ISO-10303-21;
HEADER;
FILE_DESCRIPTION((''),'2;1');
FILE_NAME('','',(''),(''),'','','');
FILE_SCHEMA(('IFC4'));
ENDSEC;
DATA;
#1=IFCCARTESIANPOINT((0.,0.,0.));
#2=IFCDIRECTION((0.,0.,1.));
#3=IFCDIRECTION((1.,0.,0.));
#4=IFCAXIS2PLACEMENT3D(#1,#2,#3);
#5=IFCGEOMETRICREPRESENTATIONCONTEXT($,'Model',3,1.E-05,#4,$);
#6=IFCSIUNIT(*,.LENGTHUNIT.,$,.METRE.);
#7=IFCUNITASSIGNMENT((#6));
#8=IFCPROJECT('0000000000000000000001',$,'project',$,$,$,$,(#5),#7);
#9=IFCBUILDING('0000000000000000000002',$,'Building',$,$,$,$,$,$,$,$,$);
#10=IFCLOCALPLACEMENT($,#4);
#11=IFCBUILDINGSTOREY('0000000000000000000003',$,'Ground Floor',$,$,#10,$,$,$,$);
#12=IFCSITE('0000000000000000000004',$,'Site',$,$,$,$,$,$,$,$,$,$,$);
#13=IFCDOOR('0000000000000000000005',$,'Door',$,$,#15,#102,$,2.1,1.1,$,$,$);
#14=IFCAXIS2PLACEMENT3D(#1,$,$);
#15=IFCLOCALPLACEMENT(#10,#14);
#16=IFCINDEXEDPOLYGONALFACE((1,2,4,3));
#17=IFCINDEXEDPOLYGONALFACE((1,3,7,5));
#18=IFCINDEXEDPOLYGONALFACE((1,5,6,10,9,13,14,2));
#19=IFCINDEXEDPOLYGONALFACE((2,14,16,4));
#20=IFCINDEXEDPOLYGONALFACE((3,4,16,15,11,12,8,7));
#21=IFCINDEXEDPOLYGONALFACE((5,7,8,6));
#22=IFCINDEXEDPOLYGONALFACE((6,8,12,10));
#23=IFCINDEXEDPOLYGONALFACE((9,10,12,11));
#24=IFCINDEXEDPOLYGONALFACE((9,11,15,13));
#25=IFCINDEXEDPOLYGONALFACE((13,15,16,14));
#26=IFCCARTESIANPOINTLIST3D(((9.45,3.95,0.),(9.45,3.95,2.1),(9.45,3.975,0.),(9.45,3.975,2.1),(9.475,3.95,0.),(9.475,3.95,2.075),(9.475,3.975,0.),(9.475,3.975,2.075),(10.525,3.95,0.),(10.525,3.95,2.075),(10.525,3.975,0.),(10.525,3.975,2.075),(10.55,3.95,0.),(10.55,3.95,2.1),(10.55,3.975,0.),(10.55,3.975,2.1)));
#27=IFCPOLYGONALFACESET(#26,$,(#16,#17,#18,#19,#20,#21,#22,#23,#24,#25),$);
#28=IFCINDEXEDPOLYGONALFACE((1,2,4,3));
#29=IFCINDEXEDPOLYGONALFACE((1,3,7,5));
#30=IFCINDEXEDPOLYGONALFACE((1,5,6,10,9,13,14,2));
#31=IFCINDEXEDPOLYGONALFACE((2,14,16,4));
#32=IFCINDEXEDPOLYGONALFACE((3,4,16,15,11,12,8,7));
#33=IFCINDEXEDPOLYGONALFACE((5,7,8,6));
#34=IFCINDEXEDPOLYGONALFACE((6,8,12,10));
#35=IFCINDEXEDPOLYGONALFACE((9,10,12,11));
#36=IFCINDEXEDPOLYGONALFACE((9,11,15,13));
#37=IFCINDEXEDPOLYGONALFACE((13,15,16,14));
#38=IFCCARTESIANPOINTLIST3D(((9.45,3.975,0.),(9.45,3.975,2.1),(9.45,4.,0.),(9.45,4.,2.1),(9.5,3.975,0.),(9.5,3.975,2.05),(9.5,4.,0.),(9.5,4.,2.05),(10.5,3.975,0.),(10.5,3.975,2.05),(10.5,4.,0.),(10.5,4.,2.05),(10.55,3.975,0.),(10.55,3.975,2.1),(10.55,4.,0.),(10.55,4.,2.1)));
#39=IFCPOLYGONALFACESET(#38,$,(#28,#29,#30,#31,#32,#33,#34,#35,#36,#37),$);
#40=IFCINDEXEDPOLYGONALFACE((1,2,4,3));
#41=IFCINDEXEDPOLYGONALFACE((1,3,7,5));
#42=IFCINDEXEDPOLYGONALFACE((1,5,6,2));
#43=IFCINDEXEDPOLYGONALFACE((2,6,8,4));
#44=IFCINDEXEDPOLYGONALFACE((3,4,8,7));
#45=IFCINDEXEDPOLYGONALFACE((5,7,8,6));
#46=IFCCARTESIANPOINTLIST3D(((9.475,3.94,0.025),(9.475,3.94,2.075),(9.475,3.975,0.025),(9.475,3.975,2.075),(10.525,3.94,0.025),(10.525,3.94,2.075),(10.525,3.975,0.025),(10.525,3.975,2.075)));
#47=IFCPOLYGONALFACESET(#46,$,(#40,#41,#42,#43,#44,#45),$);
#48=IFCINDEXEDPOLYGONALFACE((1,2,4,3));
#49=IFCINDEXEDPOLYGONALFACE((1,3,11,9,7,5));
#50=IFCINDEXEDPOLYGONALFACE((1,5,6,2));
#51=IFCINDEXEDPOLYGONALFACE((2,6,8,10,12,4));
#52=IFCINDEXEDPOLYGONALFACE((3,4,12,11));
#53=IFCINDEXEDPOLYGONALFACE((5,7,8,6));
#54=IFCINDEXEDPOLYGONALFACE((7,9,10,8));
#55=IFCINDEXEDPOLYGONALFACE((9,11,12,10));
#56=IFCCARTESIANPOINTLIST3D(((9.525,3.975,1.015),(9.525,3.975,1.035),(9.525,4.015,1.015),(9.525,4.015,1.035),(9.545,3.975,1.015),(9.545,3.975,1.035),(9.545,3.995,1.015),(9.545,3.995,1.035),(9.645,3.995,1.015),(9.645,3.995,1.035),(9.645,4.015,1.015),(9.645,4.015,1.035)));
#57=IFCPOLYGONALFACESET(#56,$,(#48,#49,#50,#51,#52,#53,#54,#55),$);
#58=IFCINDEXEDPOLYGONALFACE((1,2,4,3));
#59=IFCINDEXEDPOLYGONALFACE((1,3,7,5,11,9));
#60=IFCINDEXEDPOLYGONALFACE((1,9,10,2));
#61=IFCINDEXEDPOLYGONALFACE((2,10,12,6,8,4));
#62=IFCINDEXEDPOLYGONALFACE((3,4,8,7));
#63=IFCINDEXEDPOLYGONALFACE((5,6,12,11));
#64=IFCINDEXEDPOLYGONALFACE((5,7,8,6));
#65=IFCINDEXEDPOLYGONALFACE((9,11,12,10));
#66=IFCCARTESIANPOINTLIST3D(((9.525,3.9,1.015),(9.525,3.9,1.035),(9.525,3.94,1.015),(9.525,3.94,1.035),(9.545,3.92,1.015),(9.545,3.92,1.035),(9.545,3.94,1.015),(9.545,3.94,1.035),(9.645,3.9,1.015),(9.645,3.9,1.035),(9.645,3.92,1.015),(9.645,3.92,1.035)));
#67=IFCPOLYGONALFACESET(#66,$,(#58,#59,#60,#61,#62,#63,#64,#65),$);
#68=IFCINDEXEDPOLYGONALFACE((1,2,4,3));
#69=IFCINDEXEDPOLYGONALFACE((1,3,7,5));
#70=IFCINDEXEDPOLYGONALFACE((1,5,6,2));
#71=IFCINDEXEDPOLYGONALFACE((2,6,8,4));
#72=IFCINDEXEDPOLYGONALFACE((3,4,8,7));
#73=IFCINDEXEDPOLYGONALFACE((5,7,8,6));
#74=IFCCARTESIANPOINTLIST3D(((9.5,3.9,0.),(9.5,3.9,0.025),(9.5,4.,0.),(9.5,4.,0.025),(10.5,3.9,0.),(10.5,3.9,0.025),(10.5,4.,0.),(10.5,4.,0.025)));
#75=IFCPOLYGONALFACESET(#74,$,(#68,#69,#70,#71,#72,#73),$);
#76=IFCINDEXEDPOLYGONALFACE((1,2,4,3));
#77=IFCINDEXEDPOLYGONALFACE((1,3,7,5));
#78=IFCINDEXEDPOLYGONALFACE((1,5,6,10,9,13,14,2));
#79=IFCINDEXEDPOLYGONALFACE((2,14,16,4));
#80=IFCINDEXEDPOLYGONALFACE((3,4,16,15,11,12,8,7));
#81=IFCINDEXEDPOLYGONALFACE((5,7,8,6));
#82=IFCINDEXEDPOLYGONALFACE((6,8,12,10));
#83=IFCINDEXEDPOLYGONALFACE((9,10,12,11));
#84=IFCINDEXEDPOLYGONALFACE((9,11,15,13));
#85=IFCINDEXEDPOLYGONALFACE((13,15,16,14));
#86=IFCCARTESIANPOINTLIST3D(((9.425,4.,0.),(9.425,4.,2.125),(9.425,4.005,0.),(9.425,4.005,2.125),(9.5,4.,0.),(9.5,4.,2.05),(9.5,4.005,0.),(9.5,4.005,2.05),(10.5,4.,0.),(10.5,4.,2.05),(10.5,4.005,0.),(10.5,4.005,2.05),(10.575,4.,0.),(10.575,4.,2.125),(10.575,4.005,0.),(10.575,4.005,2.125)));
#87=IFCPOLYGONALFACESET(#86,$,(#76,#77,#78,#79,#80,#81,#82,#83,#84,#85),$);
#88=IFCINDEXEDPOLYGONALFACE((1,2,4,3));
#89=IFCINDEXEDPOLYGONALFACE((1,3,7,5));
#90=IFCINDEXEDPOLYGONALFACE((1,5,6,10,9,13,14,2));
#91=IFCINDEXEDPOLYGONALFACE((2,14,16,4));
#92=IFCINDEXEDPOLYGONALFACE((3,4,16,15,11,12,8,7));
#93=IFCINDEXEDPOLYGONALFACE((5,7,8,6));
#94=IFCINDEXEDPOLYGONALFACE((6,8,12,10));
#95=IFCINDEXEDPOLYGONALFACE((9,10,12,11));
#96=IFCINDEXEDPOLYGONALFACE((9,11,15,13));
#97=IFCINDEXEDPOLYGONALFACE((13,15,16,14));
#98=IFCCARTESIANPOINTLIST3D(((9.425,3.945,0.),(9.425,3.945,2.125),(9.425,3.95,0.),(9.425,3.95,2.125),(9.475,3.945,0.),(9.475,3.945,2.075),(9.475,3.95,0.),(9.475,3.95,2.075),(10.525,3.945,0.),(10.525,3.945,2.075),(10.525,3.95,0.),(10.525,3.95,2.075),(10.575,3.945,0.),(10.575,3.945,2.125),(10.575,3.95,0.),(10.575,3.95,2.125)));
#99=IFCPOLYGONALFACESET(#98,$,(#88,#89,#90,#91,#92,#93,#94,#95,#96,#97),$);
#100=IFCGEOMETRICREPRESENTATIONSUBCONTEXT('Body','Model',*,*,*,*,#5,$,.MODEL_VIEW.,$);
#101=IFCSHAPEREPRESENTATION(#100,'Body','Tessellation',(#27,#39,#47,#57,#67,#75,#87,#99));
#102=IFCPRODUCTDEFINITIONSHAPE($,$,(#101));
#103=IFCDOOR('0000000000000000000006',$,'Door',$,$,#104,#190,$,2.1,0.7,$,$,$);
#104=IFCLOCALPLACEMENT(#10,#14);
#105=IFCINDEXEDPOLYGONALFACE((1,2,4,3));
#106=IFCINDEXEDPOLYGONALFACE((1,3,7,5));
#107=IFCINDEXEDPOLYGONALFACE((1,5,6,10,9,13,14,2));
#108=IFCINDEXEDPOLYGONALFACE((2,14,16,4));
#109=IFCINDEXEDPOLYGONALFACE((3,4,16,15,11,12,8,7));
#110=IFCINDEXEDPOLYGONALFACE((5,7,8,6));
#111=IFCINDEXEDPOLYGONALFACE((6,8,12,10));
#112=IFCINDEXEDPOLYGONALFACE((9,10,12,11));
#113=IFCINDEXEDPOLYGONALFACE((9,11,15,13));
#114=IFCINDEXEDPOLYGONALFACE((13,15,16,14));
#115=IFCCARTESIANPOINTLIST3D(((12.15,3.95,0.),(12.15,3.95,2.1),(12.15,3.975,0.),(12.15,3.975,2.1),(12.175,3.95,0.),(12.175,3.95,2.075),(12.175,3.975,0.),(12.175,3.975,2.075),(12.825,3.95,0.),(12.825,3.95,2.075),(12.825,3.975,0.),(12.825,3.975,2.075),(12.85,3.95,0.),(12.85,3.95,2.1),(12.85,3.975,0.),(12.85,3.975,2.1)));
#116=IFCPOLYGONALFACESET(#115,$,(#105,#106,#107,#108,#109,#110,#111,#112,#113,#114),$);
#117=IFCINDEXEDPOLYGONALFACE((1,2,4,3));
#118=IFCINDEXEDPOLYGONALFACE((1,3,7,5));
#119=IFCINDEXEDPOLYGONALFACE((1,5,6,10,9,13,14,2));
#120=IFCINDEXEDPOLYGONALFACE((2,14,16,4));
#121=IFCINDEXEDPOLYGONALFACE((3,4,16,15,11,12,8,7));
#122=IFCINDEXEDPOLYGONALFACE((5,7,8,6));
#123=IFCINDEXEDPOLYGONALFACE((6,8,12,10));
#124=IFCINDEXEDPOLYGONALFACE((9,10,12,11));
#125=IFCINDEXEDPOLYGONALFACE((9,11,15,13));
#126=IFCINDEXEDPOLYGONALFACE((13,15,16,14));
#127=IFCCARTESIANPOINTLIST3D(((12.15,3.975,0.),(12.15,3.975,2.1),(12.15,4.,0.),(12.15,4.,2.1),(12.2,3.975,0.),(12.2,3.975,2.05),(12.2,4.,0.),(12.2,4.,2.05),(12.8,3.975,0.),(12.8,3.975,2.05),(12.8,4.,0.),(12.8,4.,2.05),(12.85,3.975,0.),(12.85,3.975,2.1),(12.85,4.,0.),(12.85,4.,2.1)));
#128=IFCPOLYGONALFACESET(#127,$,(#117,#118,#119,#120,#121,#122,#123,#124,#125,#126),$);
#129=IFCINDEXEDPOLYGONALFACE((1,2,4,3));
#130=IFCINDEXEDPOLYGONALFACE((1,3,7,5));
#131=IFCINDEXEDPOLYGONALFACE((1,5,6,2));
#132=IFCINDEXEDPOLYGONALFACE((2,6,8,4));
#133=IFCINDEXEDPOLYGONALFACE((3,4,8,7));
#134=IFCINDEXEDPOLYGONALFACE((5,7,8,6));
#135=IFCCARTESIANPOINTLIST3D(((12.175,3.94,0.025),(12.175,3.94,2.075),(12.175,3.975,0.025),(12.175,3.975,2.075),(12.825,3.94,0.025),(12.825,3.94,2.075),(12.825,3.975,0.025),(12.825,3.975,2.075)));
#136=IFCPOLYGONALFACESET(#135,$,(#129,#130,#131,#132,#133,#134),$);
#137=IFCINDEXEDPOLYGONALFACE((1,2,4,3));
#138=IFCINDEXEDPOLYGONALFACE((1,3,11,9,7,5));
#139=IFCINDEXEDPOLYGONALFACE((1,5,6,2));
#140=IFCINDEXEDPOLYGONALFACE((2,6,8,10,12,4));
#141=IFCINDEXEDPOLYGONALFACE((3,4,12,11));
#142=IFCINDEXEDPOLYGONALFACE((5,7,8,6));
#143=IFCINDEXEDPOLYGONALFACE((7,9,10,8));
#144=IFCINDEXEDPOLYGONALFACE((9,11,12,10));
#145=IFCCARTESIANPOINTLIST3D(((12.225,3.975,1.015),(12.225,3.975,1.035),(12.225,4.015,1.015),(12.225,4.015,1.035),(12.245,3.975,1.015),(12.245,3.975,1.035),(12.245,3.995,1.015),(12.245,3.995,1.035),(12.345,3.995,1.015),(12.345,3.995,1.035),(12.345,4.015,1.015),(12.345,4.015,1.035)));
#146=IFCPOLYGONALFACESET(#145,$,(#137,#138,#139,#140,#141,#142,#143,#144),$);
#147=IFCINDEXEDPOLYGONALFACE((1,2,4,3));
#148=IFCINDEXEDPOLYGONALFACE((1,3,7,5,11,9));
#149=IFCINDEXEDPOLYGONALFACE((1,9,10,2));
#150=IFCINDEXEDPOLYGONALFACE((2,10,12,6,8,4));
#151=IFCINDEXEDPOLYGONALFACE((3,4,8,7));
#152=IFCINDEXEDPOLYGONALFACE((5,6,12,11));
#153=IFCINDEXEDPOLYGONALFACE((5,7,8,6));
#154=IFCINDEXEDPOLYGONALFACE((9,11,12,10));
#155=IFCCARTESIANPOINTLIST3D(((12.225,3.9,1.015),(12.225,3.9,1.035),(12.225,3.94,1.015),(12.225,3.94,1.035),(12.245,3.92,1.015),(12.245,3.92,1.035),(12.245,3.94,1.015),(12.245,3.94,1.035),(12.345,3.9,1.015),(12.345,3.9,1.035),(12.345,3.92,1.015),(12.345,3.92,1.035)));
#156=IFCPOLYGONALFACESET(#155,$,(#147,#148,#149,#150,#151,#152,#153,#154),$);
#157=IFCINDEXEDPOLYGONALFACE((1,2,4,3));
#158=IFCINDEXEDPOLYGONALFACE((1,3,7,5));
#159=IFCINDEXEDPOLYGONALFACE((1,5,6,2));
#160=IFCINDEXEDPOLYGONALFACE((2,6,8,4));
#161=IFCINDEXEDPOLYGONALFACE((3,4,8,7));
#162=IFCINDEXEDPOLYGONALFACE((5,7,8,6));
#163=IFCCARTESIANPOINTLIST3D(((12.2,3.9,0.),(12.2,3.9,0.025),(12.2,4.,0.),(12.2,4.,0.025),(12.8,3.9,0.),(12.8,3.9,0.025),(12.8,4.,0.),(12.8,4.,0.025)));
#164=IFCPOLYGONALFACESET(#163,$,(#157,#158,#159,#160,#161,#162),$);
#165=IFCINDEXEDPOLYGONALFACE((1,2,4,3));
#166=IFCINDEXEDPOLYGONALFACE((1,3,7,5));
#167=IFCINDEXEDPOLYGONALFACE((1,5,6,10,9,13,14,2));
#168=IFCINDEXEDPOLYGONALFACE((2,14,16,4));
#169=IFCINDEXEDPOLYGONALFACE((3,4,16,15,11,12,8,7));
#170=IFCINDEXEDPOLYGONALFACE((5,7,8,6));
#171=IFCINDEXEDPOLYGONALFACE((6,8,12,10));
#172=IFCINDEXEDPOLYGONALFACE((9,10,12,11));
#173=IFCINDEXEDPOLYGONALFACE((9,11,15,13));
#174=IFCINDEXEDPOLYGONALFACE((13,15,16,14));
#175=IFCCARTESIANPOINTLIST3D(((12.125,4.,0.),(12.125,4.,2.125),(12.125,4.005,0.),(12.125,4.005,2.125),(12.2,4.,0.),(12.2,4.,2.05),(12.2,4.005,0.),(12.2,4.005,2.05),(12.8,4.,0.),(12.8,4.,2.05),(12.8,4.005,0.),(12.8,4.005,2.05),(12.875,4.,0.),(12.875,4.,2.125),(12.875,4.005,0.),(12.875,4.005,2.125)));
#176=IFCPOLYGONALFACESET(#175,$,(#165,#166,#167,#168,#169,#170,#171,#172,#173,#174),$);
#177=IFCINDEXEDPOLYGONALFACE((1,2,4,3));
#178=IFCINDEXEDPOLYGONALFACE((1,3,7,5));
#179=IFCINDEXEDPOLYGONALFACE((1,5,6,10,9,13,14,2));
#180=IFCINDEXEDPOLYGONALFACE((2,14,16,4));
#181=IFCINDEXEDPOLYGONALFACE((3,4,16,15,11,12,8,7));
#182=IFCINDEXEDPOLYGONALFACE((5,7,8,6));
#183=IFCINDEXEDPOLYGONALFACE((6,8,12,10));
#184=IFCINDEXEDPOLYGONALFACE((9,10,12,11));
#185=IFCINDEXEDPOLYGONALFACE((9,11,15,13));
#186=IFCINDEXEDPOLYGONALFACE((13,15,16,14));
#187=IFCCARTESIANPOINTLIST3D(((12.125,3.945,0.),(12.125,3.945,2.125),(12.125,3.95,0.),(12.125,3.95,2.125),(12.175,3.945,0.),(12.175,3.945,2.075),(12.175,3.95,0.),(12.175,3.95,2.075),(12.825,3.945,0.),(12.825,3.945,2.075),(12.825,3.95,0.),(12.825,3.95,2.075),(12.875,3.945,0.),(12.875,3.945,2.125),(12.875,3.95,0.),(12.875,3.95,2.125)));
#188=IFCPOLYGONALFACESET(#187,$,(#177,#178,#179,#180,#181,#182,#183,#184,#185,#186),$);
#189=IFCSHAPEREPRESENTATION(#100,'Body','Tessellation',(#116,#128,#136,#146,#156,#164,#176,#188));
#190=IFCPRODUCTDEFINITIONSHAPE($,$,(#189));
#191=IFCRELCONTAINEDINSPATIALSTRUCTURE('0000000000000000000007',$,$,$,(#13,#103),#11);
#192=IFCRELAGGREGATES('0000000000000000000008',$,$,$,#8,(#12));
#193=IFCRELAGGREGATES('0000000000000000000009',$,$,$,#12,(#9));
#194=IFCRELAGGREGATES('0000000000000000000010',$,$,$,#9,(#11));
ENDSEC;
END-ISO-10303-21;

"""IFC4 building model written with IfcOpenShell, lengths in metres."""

from ifc_helpers import new_model, si_unit, frame, origin_with_axes, place, context, subcontext, project, spatial, line, indexed_curve, outline, extrude, element, save


model = new_model("IFC4")

# Units and contexts
model_context = context("Model", 3, precision=1e-05, world=origin_with_axes())
body_context = subcontext(model_context, "Body", "Model", "MODEL_VIEW")
ifc_project = project(units=[si_unit("LENGTHUNIT", "METRE")], contexts=[model_context])

# Site, building, storey
site = spatial("IfcSite", under=ifc_project, Name="Site")
building = spatial("IfcBuilding", under=site, Name="Building")
storey_placement = place(None, origin_with_axes())
storey = spatial("IfcBuildingStorey", under=building, at=storey_placement, Name="Ground Floor")

# Doors
door_1_placement = place(storey_placement, frame((10.55, 4.0, 0.0), z_axis=(0.0, 0.0, 1.0), x_axis=(-1.0, 0.0, 0.0)))
element("IfcDoor", 1, at=door_1_placement, inside=storey, Name="Door", OverallHeight=2.1, OverallWidth=1.1, context=body_context, shape_type="SweptSolid", body=[
    extrude(outline(indexed_curve([(0.0, 0.0), (0.0, 2.1), (1.1, 2.1), (1.1, 0.0), (1.075, 0.0), (1.075, 2.075), (0.025, 2.075), (0.025, 0.0)], segments=[line(1, 2, 3, 4, 5, 6, 7, 8, 1)])), frame((0.0, 0.025, 0.0), z_axis=(0.0, -1.0, 0.0), x_axis=(1.0, 0.0, 0.0)), (0.0, 0.0, -1.0), 0.025),
    extrude(outline(indexed_curve([(0.0, 0.0), (0.0, 2.1), (1.1, 2.1), (1.1, 0.0), (1.05, 0.0), (1.05, 2.05), (0.05, 2.05), (0.05, 0.0)], segments=[line(1, 2, 3, 4, 5, 6, 7, 8, 1)])), frame((0.0, 0.0, 0.0), z_axis=(0.0, -1.0, 0.0), x_axis=(1.0, 0.0, 0.0)), (0.0, 0.0, -1.0), 0.025),
    extrude(outline(indexed_curve([(0.0, 0.0), (1.05, 0.0), (1.05, 0.035), (0.0, 0.035)], segments=[line(1, 2, 3, 4, 1)])), frame((0.025, 0.025, 0.025), z_axis=(0.0, 0.0, 1.0), x_axis=(1.0, 0.0, 0.0)), (0.0, 0.0, 1.0), 2.05),
    extrude(outline(indexed_curve([(0.0, 0.0), (0.0, -0.04), (-0.12, -0.04), (-0.12, -0.02), (-0.02, -0.02), (-0.02, 0.0)], segments=[line(1, 2, 3, 4, 5, 6, 1)])), frame((1.025, 0.025, 1.015), z_axis=(0.0, 0.0, 1.0), x_axis=(1.0, 0.0, 0.0)), (0.0, 0.0, 1.0), 0.02),
    extrude(outline(indexed_curve([(0.0, 0.0), (0.0, 0.04), (-0.12, 0.04), (-0.12, 0.02), (-0.02, 0.02), (-0.02, 0.0)], segments=[line(1, 2, 3, 4, 5, 6, 1)])), frame((1.025, 0.06, 1.015), z_axis=(0.0, 0.0, 1.0), x_axis=(1.0, 0.0, 0.0)), (0.0, 0.0, 1.0), 0.02),
    extrude(outline(indexed_curve([(0.0, 0.0), (1.0, 0.0), (1.0, 0.1), (0.0, 0.1)], segments=[line(1, 2, 3, 4, 1)])), frame((0.05, 0.0, 0.0), z_axis=(0.0, 0.0, 1.0), x_axis=(1.0, 0.0, 0.0)), (0.0, 0.0, 1.0), 0.025),
    extrude(outline(indexed_curve([(0.0, 0.0), (0.0, 2.125), (1.15, 2.125), (1.15, 0.0), (1.075, 0.0), (1.075, 2.05), (0.075, 2.05), (0.075, 0.0)], segments=[line(1, 2, 3, 4, 5, 6, 7, 8, 1)])), frame((-0.025, -0.005, 0.0), z_axis=(0.0, -1.0, 0.0), x_axis=(1.0, 0.0, 0.0)), (0.0, 0.0, -1.0), 0.005),
    extrude(outline(indexed_curve([(0.0, 0.0), (0.0, 2.125), (1.15, 2.125), (1.15, 0.0), (1.1, 0.0), (1.1, 2.075), (0.05, 2.075), (0.05, 0.0)], segments=[line(1, 2, 3, 4, 5, 6, 7, 8, 1)])), frame((-0.025, 0.05, 0.0), z_axis=(0.0, -1.0, 0.0), x_axis=(1.0, 0.0, 0.0)), (0.0, 0.0, -1.0), 0.005),
])
door_2_placement = place(storey_placement, frame((12.85, 4.0, 0.0), z_axis=(0.0, 0.0, 1.0), x_axis=(-1.0, 0.0, 0.0)))
element("IfcDoor", 2, at=door_2_placement, inside=storey, Name="Door", OverallHeight=2.1, OverallWidth=0.7, context=body_context, shape_type="SweptSolid", body=[
    extrude(outline(indexed_curve([(0.0, 0.0), (0.0, 2.1), (0.7, 2.1), (0.7, 0.0), (0.675, 0.0), (0.675, 2.075), (0.025, 2.075), (0.025, 0.0)], segments=[line(1, 2, 3, 4, 5, 6, 7, 8, 1)])), frame((0.0, 0.025, 0.0), z_axis=(0.0, -1.0, 0.0), x_axis=(1.0, 0.0, 0.0)), (0.0, 0.0, -1.0), 0.025),
    extrude(outline(indexed_curve([(0.0, 0.0), (0.0, 2.1), (0.7, 2.1), (0.7, 0.0), (0.65, 0.0), (0.65, 2.05), (0.05, 2.05), (0.05, 0.0)], segments=[line(1, 2, 3, 4, 5, 6, 7, 8, 1)])), frame((0.0, 0.0, 0.0), z_axis=(0.0, -1.0, 0.0), x_axis=(1.0, 0.0, 0.0)), (0.0, 0.0, -1.0), 0.025),
    extrude(outline(indexed_curve([(0.0, 0.0), (0.65, 0.0), (0.65, 0.035), (0.0, 0.035)], segments=[line(1, 2, 3, 4, 1)])), frame((0.025, 0.025, 0.025), z_axis=(0.0, 0.0, 1.0), x_axis=(1.0, 0.0, 0.0)), (0.0, 0.0, 1.0), 2.05),
    extrude(outline(indexed_curve([(0.0, 0.0), (0.0, -0.04), (-0.12, -0.04), (-0.12, -0.02), (-0.02, -0.02), (-0.02, 0.0)], segments=[line(1, 2, 3, 4, 5, 6, 1)])), frame((0.625, 0.025, 1.015), z_axis=(0.0, 0.0, 1.0), x_axis=(1.0, 0.0, 0.0)), (0.0, 0.0, 1.0), 0.02),
    extrude(outline(indexed_curve([(0.0, 0.0), (0.0, 0.04), (-0.12, 0.04), (-0.12, 0.02), (-0.02, 0.02), (-0.02, 0.0)], segments=[line(1, 2, 3, 4, 5, 6, 1)])), frame((0.625, 0.06, 1.015), z_axis=(0.0, 0.0, 1.0), x_axis=(1.0, 0.0, 0.0)), (0.0, 0.0, 1.0), 0.02),
    extrude(outline(indexed_curve([(0.0, 0.0), (0.6, 0.0), (0.6, 0.1), (0.0, 0.1)], segments=[line(1, 2, 3, 4, 1)])), frame((0.05, 0.0, 0.0), z_axis=(0.0, 0.0, 1.0), x_axis=(1.0, 0.0, 0.0)), (0.0, 0.0, 1.0), 0.025),
    extrude(outline(indexed_curve([(0.0, 0.0), (0.0, 2.125), (0.75, 2.125), (0.75, 0.0), (0.675, 0.0), (0.675, 2.05), (0.075, 2.05), (0.075, 0.0)], segments=[line(1, 2, 3, 4, 5, 6, 7, 8, 1)])), frame((-0.025, -0.005, 0.0), z_axis=(0.0, -1.0, 0.0), x_axis=(1.0, 0.0, 0.0)), (0.0, 0.0, -1.0), 0.005),
    extrude(outline(indexed_curve([(0.0, 0.0), (0.0, 2.125), (0.75, 2.125), (0.75, 0.0), (0.7, 0.0), (0.7, 2.075), (0.05, 2.075), (0.05, 0.0)], segments=[line(1, 2, 3, 4, 5, 6, 7, 8, 1)])), frame((-0.025, 0.05, 0.0), z_axis=(0.0, -1.0, 0.0), x_axis=(1.0, 0.0, 0.0)), (0.0, 0.0, -1.0), 0.005),
])

save(model, "model.ifc")
